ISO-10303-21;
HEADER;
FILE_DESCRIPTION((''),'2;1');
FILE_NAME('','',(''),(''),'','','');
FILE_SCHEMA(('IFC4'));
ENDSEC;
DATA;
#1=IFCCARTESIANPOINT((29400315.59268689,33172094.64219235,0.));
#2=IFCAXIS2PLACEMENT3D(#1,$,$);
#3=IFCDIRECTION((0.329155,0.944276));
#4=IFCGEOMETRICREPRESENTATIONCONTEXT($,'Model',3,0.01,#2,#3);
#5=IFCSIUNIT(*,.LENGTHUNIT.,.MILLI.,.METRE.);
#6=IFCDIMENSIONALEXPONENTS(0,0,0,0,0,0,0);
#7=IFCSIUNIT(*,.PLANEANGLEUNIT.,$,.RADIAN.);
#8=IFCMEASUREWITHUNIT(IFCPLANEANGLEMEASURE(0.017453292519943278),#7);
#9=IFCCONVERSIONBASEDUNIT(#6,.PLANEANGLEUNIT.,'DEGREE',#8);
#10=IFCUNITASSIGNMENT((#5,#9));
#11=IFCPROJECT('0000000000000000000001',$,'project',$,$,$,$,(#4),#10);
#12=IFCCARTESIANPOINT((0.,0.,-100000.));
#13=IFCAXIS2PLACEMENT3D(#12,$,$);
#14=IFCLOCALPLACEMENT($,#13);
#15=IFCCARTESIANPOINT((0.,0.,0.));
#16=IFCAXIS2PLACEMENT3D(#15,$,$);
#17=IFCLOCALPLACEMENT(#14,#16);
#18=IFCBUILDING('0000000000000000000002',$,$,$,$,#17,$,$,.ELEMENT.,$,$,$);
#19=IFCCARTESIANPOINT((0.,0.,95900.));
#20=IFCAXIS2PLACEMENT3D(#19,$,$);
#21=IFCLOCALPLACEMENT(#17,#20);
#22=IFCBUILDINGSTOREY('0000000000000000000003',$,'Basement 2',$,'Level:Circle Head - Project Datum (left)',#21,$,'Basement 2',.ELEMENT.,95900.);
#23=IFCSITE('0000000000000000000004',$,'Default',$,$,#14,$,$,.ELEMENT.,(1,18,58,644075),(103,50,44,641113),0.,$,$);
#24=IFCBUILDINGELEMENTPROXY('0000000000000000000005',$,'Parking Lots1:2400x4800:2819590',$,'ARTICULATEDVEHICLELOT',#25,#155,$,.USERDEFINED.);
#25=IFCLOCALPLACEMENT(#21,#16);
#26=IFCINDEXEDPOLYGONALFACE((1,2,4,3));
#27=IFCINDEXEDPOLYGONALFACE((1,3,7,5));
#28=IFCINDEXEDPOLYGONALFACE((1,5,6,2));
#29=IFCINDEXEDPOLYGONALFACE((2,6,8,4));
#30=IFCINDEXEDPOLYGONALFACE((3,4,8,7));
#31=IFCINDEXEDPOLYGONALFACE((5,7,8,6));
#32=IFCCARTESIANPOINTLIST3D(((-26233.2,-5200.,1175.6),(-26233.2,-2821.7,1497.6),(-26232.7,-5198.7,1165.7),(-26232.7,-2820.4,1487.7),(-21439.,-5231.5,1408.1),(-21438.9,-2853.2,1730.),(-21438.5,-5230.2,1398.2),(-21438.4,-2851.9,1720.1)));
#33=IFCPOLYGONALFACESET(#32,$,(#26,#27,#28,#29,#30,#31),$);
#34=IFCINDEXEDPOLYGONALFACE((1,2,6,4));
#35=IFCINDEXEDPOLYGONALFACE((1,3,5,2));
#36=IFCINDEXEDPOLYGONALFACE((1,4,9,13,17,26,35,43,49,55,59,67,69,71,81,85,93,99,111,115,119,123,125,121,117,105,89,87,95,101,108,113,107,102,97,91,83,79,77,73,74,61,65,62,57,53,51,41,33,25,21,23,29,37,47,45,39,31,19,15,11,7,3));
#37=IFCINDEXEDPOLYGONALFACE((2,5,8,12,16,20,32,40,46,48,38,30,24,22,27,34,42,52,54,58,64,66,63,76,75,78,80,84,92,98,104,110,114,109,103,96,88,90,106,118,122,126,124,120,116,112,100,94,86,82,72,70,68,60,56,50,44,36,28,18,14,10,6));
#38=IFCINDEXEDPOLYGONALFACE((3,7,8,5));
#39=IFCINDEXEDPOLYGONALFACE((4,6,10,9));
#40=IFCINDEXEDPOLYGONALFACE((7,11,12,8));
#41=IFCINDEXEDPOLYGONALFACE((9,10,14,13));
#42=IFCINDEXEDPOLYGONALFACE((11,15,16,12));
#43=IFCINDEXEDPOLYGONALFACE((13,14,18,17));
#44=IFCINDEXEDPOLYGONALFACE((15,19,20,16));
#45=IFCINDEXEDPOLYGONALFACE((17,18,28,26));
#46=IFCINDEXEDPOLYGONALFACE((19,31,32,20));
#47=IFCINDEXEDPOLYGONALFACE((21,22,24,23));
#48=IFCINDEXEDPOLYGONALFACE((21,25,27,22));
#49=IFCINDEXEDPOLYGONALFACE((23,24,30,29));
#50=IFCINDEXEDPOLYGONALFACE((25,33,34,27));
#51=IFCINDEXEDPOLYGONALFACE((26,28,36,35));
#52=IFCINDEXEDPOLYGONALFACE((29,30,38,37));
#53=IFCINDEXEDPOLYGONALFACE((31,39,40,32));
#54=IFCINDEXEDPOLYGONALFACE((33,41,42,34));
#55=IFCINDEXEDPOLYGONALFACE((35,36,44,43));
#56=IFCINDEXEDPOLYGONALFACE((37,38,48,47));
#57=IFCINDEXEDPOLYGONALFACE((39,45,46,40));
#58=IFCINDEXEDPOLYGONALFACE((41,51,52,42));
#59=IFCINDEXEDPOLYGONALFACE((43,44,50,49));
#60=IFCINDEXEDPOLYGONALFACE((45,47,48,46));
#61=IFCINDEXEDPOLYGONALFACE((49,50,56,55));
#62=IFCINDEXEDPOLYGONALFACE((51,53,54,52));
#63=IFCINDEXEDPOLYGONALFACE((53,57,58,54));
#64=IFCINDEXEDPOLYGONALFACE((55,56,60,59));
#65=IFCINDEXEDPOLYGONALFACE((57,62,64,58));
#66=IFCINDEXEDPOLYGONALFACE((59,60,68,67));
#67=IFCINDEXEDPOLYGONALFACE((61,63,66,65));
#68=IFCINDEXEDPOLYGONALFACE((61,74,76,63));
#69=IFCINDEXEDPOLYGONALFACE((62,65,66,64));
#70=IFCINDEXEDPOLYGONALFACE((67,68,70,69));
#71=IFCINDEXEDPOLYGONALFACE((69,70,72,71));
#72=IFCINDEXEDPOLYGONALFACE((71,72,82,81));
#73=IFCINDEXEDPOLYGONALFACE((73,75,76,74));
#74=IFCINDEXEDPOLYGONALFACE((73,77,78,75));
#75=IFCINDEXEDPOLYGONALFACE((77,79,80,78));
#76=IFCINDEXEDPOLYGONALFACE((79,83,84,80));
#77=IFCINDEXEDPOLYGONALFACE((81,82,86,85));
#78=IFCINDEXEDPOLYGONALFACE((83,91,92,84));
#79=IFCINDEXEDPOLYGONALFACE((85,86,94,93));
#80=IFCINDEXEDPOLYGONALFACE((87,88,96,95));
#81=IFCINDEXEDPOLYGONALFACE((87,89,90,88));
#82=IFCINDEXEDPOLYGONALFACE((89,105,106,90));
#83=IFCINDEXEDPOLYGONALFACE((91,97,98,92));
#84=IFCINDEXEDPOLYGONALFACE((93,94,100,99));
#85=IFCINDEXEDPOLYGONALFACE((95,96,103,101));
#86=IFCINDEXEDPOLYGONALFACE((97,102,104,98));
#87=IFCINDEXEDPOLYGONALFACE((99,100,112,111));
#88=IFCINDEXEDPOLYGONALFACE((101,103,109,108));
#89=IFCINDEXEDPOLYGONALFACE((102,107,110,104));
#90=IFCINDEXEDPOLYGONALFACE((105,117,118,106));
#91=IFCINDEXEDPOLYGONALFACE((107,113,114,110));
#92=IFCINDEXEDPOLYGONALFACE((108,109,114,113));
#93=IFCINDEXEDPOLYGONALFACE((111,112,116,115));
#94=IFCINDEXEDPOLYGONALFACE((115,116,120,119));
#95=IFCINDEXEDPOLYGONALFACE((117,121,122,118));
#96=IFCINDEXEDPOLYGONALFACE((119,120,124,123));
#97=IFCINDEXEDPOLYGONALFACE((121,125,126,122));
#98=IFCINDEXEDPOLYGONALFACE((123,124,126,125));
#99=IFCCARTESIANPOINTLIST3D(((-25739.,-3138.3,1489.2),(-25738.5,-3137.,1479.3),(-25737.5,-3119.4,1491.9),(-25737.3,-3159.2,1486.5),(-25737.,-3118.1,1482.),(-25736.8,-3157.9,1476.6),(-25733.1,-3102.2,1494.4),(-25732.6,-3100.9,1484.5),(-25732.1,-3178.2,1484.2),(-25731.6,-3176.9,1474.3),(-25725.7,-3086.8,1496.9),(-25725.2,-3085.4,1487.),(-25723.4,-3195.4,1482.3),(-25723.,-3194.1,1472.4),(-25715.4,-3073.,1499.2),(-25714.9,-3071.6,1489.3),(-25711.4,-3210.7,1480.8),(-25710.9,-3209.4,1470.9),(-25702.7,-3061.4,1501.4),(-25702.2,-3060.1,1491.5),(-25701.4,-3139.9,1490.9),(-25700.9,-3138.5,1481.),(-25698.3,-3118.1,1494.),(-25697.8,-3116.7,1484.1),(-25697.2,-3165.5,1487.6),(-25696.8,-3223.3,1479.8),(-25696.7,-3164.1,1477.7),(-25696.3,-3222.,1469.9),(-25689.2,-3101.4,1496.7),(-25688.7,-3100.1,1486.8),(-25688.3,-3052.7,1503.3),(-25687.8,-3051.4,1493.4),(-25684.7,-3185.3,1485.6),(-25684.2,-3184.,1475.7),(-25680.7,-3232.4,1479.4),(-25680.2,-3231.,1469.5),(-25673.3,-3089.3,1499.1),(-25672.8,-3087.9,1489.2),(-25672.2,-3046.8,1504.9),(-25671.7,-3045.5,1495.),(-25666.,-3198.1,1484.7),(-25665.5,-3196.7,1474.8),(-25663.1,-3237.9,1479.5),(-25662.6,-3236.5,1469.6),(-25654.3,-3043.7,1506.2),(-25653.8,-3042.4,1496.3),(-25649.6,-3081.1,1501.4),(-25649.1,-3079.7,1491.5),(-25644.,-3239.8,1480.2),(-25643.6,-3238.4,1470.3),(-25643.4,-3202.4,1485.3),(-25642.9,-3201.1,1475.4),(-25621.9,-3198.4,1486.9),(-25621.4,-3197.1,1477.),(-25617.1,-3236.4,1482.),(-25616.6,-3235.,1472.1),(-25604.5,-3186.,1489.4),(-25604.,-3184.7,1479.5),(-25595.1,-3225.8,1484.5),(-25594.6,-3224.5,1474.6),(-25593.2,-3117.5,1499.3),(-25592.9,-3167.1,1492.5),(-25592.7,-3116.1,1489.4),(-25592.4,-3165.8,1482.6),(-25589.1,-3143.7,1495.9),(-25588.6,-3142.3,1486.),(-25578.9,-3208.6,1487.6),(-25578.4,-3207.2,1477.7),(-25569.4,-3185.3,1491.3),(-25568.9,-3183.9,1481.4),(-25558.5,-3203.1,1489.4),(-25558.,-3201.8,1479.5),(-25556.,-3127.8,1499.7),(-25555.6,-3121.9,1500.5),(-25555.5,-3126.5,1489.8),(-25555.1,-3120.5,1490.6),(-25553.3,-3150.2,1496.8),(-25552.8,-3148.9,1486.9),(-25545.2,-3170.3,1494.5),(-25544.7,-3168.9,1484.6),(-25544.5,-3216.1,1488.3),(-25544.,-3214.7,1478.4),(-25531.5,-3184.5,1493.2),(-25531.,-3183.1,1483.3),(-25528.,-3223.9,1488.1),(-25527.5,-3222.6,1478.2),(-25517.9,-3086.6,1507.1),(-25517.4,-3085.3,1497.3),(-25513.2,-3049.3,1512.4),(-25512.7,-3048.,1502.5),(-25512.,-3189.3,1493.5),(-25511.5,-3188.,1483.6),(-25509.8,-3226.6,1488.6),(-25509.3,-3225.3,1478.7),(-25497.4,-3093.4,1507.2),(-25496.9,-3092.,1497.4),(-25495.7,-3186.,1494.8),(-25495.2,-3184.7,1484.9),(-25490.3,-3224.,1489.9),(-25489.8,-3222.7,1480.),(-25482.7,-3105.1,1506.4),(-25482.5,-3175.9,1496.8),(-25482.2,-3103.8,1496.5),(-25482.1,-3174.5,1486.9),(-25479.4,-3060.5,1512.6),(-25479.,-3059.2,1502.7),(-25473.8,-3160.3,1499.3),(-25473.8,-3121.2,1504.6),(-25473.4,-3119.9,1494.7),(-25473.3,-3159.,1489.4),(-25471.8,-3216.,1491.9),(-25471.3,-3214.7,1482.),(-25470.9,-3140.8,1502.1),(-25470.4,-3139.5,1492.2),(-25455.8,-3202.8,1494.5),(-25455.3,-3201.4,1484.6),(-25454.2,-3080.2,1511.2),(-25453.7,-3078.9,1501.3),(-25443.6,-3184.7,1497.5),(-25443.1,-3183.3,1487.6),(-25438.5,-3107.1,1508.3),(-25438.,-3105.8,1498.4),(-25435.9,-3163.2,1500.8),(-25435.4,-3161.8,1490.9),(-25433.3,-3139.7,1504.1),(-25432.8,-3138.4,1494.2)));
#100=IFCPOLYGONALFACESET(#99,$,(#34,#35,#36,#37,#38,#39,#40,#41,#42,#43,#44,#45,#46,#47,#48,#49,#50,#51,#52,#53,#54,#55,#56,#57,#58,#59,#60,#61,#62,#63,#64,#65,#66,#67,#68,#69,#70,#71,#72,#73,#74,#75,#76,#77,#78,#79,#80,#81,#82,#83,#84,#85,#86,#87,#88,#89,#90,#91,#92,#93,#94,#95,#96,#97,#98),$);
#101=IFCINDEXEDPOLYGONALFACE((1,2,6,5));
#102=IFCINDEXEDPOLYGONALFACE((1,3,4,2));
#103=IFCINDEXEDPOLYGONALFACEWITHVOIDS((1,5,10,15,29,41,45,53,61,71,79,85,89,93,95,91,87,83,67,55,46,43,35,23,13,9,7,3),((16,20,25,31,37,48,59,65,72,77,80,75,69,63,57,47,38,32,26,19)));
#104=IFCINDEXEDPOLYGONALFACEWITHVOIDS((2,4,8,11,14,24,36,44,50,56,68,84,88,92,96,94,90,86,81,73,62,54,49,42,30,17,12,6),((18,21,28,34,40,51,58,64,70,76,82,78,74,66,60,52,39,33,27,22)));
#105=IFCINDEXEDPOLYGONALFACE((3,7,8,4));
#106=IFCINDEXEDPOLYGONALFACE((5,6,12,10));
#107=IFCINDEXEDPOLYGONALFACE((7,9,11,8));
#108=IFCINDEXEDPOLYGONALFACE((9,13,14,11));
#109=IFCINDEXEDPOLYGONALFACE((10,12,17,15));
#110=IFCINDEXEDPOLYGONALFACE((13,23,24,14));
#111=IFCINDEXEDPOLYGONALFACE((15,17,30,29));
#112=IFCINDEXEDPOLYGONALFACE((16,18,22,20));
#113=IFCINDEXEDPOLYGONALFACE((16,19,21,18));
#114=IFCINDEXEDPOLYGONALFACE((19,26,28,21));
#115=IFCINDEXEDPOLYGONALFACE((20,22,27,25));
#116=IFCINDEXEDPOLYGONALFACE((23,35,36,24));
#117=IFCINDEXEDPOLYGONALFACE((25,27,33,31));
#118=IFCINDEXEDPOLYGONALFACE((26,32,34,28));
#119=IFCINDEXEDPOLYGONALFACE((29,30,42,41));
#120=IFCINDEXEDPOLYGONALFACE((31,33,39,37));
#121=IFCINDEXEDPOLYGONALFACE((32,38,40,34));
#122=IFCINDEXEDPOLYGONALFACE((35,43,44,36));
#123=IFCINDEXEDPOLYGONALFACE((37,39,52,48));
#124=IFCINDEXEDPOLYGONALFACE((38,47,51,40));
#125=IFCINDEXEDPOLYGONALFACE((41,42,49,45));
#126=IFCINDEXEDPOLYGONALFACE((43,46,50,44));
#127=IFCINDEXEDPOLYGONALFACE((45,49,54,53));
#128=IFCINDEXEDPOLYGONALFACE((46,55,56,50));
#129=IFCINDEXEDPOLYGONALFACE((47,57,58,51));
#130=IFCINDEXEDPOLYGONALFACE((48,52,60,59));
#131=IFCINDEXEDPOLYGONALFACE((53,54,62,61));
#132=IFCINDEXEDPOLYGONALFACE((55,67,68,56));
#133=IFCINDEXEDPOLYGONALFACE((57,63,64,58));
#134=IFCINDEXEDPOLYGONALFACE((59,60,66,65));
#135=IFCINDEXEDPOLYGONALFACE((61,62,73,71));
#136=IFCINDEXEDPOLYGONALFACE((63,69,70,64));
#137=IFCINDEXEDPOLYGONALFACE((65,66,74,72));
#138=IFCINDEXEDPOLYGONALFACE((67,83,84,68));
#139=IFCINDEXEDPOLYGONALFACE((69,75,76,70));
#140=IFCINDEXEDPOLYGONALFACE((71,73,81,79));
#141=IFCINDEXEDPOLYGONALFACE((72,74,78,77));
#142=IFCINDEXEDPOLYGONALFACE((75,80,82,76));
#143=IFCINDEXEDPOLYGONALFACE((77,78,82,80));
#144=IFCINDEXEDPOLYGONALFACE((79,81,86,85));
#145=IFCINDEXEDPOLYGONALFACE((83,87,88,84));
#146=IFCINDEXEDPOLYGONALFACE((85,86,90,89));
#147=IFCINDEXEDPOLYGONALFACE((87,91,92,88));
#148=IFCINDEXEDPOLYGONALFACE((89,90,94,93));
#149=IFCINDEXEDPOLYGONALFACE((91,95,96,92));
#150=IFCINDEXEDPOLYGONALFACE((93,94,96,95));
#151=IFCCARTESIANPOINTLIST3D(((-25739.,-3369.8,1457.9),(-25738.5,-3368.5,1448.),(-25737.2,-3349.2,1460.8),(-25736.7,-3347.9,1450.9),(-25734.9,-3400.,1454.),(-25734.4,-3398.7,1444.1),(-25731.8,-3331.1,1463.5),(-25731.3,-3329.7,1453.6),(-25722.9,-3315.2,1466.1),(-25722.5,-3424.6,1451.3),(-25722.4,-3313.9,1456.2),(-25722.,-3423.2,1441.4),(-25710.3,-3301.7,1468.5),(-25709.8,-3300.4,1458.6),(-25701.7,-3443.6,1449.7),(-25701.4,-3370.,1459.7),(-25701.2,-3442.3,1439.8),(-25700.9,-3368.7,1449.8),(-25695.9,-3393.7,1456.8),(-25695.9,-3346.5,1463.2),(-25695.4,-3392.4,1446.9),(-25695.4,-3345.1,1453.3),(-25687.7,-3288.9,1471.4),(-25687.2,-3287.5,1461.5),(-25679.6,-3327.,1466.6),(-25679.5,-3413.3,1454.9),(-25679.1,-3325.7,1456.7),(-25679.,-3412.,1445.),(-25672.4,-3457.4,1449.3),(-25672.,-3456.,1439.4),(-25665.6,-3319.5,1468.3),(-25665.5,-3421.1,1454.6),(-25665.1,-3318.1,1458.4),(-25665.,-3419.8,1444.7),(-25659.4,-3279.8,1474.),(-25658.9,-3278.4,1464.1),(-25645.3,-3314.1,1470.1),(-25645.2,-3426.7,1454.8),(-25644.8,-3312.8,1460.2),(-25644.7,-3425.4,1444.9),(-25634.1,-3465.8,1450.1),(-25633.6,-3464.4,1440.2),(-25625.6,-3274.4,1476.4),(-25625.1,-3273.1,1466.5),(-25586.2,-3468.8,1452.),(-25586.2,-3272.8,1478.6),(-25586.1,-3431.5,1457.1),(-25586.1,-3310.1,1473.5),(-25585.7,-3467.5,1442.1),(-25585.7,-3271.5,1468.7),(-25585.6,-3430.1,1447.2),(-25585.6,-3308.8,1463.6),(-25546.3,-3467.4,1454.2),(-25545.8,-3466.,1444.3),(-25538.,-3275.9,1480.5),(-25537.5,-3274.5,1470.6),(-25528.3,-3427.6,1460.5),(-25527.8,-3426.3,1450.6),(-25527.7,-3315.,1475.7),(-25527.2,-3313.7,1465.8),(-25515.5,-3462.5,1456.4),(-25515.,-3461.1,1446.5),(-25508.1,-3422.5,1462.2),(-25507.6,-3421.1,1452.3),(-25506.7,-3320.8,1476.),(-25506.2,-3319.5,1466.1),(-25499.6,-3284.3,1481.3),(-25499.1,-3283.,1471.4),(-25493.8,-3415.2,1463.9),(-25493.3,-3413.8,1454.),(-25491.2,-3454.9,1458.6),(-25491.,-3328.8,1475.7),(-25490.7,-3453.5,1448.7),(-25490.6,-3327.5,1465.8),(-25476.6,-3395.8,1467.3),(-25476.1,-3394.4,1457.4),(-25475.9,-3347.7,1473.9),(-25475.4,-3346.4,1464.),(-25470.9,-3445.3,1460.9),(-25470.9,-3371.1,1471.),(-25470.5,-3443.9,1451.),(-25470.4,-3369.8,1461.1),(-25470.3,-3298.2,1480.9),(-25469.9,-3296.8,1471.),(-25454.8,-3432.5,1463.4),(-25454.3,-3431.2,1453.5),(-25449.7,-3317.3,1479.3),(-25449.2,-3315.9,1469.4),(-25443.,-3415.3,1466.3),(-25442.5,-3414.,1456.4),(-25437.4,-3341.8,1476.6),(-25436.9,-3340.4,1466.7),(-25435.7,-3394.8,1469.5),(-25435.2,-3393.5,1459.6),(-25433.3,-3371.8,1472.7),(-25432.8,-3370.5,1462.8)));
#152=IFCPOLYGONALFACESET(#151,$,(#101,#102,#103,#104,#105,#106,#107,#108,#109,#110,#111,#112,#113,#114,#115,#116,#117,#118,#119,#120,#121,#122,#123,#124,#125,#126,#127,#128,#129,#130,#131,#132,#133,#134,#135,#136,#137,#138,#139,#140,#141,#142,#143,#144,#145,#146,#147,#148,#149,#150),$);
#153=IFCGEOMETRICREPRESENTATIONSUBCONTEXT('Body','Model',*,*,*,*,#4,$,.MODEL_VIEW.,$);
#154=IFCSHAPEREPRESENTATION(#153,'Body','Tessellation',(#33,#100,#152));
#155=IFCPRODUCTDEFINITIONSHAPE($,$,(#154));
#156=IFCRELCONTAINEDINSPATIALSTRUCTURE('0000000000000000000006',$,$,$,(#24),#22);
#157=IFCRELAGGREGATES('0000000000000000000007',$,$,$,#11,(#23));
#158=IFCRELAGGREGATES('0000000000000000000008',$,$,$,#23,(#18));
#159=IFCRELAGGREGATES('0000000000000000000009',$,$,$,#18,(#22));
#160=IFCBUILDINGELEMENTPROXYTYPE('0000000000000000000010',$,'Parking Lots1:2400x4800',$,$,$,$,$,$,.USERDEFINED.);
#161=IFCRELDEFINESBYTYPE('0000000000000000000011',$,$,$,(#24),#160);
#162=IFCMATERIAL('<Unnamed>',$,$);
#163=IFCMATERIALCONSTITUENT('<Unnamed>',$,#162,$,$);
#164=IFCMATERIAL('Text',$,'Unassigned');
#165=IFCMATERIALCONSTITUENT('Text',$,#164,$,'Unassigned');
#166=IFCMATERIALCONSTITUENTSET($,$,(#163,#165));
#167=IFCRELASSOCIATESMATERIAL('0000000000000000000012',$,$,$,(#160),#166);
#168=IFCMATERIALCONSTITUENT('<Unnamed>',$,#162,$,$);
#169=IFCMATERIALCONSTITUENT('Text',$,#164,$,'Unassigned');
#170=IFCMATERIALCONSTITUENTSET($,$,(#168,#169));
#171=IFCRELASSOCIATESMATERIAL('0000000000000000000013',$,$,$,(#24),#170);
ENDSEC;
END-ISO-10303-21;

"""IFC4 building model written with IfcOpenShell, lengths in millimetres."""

from ifc_helpers import new_model, entity, si_unit, converted_unit, direction, frame, origin, place, context, subcontext, project, spatial, indexed_curve, outline, extrude, source, transform, mapped, material, constituent, constituent_set, type_object, type_shapes, element, save


model = new_model("IFC4")

# Units and contexts
model_context = context("Model", 3, precision=0.01, world=frame((29400315.59268689, 33172094.64219235, 0.0)), true_north=direction((0.329155, 0.944276)))
body_context = subcontext(model_context, "Body", "Model", "MODEL_VIEW")
ifc_project = project(units=[si_unit("LENGTHUNIT", "METRE", prefix="MILLI"), converted_unit("PLANEANGLEUNIT", "DEGREE", entity("IfcPlaneAngleMeasure", 0.017453292519943278), si_unit("PLANEANGLEUNIT", "RADIAN"), dimensions=[0, 0, 0, 0, 0, 0, 0])], contexts=[model_context])

# Site, building, storey
site_placement = place(None, frame((0.0, 0.0, -100000.0)))
site = spatial("IfcSite", under=ifc_project, at=site_placement, Name="Default", CompositionType="ELEMENT", RefLatitude=(1, 18, 58, 644075), RefLongitude=(103, 50, 44, 641113), RefElevation=0.0)
building_placement = place(site_placement, origin())
building = spatial("IfcBuilding", under=site, at=building_placement, CompositionType="ELEMENT")
storey_placement = place(building_placement, frame((0.0, 0.0, 95900.0)))
storey = spatial("IfcBuildingStorey", under=building, at=storey_placement, Name="Basement 2", ObjectType="Level:Circle Head - Project Datum (left)", LongName="Basement 2", CompositionType="ELEMENT", Elevation=95900.0)

# Shared definitions
ifc_material_1 = material(Name="<Unnamed>")

# Building element proxy
ifc_material_2 = material(Name="Text", Category="Unassigned")
ifc_constituent_1 = constituent(ifc_material_1, Name="<Unnamed>")
ifc_constituent_2 = constituent(ifc_material_2, Name="Text", Category="Unassigned")
ifc_constituent_set_1 = constituent_set(constituents=[ifc_constituent_1, ifc_constituent_2])
ifc_constituent_3 = constituent(ifc_material_1, Name="<Unnamed>")
ifc_constituent_4 = constituent(ifc_material_2, Name="Text", Category="Unassigned")
ifc_constituent_set_2 = constituent_set(constituents=[ifc_constituent_3, ifc_constituent_4])
building_element_proxy_type_1 = type_object("IfcBuildingElementProxyType", Name="Parking Lots1:2400x4800", PredefinedType="USERDEFINED", material=ifc_constituent_set_2)
shared_shape_1 = source(origin(), body_context, "Body", "SweptSolid", [
    extrude(outline(indexed_curve([(-1200.0, -2400.0), (1200.0, -2400.0), (1200.0, 2400.0), (-1200.0, 2400.0), (-1200.0, -2400.0)], self_intersect=False)), frame((1200.0, -2400.0, 0.0), z_axis=(0.0, 0.0, 1.0), x_axis=(-1.0, 0.0, 0.0)), (0.0, 0.0, 1.0), 10.0),
    extrude(outline(indexed_curve([(41.2, -119.5), (59.4, -119.5), (76.4, -116.4), (92.1, -110.3), (106.7, -101.0), (119.4, -89.1), (129.4, -75.0), (136.9, -58.7), (141.8, -40.2), (143.8, -19.2), (142.2, 0.6), (136.7, 19.2), (127.6, 36.5), (115.5, 51.5), (101.3, 63.2), (84.9, 71.7), (66.4, 76.9), (39.2, 78.2), (15.6, 71.5), (-3.5, 57.2), (-17.0, 35.7), (-24.5, 55.3), (-36.1, 70.5), (-50.9, 81.2), (-68.4, 87.0), (-88.1, 87.8), (-107.7, 83.0), (-125.9, 72.6), (-141.2, 56.8), (-152.7, 36.8), (-159.5, 13.9), (-160.2, -19.4), (-149.6, -48.7), (-128.2, -72.7), (-96.9, -89.6), (-85.6, -53.4), (-104.7, -43.2), (-117.0, -28.9), (-122.8, -11.5), (-122.2, 8.5), (-115.8, 27.4), (-104.4, 41.3), (-89.5, 49.1), (-72.9, 49.6), (-54.6, 41.4), (-43.6, 24.9), (-39.2, 3.6), (-40.6, -19.0), (-42.1, -24.9), (-5.8, -35.8), (-5.1, -9.0), (2.9, 13.6), (17.7, 30.3), (37.1, 39.7), (59.0, 40.0), (80.6, 31.7), (96.7, 15.8), (105.4, -6.0), (104.9, -32.2), (98.0, -53.3), (86.0, -68.3), (68.1, -77.6), (43.3, -81.6), (41.2, -119.5)], self_intersect=False)), frame((329.1, -4158.0, 10.0), z_axis=(0.0, 0.0, 1.0), x_axis=(0.178774, -0.98389, 0.0)), (0.0, 0.0, 1.0), 10.0),
    extrude(outline(indexed_curve([(-5.6, -99.5), (33.9, -99.5), (68.0, -95.5), (96.7, -87.5), (120.0, -75.5), (133.2, -62.4), (142.9, -46.8), (149.1, -28.7), (151.9, -8.0), (149.2, 22.6), (138.0, 47.8), (118.2, 67.9), (89.5, 82.9), (51.6, 93.0), (3.8, 98.0), (-36.2, 98.2), (-67.3, 94.5), (-91.9, 87.9), (-112.6, 79.0), (-129.4, 66.8), (-142.0, 50.0), (-150.3, 29.6), (-153.8, 6.5), (-151.2, -23.9), (-140.1, -49.1), (-120.3, -69.2), (-91.7, -84.4), (-53.6, -94.5), (-5.6, -99.5)], self_intersect=False), holes=[indexed_curve([(-3.9, -61.9), (-62.1, -54.6), (-82.9, -47.9), (-98.1, -39.2), (-112.3, -19.5), (-116.2, 4.3), (-109.3, 28.9), (-91.2, 47.7), (-76.5, 54.5), (-56.1, 58.9), (1.9, 60.4), (60.8, 53.2), (80.8, 46.7), (94.5, 38.3), (109.9, 17.8), (114.3, -6.3), (107.7, -29.8), (90.4, -48.7), (76.0, -55.8), (55.5, -60.3), (-3.9, -61.9)], self_intersect=False)]), frame((549.3, -4152.6, 10.0), z_axis=(0.0, 0.0, 1.0), x_axis=(0.047515, -0.998871, 0.0)), (0.0, 0.0, 1.0), 10.0),
])
type_shapes(building_element_proxy_type_1, [shared_shape_1])
proxy_1_placement = place(storey_placement, frame((-21438.4, -2851.9, 1720.1), z_axis=(-0.048866, -0.133991, 0.989777), x_axis=(-0.000014, -0.990961, -0.134152)))
element("IfcBuildingElementProxy", 1, at=proxy_1_placement, inside=storey, type_object=building_element_proxy_type_1, material=ifc_constituent_set_1, Name="Parking Lots1:2400x4800:2819590", ObjectType="ARTICULATEDVEHICLELOT", PredefinedType="USERDEFINED", context=body_context, shape_type="MappedRepresentation", body=[
    mapped(shared_shape_1, transform((0.0, 0.0, 0.0), scale=1.0)),
])

save(model, "model.ifc")
